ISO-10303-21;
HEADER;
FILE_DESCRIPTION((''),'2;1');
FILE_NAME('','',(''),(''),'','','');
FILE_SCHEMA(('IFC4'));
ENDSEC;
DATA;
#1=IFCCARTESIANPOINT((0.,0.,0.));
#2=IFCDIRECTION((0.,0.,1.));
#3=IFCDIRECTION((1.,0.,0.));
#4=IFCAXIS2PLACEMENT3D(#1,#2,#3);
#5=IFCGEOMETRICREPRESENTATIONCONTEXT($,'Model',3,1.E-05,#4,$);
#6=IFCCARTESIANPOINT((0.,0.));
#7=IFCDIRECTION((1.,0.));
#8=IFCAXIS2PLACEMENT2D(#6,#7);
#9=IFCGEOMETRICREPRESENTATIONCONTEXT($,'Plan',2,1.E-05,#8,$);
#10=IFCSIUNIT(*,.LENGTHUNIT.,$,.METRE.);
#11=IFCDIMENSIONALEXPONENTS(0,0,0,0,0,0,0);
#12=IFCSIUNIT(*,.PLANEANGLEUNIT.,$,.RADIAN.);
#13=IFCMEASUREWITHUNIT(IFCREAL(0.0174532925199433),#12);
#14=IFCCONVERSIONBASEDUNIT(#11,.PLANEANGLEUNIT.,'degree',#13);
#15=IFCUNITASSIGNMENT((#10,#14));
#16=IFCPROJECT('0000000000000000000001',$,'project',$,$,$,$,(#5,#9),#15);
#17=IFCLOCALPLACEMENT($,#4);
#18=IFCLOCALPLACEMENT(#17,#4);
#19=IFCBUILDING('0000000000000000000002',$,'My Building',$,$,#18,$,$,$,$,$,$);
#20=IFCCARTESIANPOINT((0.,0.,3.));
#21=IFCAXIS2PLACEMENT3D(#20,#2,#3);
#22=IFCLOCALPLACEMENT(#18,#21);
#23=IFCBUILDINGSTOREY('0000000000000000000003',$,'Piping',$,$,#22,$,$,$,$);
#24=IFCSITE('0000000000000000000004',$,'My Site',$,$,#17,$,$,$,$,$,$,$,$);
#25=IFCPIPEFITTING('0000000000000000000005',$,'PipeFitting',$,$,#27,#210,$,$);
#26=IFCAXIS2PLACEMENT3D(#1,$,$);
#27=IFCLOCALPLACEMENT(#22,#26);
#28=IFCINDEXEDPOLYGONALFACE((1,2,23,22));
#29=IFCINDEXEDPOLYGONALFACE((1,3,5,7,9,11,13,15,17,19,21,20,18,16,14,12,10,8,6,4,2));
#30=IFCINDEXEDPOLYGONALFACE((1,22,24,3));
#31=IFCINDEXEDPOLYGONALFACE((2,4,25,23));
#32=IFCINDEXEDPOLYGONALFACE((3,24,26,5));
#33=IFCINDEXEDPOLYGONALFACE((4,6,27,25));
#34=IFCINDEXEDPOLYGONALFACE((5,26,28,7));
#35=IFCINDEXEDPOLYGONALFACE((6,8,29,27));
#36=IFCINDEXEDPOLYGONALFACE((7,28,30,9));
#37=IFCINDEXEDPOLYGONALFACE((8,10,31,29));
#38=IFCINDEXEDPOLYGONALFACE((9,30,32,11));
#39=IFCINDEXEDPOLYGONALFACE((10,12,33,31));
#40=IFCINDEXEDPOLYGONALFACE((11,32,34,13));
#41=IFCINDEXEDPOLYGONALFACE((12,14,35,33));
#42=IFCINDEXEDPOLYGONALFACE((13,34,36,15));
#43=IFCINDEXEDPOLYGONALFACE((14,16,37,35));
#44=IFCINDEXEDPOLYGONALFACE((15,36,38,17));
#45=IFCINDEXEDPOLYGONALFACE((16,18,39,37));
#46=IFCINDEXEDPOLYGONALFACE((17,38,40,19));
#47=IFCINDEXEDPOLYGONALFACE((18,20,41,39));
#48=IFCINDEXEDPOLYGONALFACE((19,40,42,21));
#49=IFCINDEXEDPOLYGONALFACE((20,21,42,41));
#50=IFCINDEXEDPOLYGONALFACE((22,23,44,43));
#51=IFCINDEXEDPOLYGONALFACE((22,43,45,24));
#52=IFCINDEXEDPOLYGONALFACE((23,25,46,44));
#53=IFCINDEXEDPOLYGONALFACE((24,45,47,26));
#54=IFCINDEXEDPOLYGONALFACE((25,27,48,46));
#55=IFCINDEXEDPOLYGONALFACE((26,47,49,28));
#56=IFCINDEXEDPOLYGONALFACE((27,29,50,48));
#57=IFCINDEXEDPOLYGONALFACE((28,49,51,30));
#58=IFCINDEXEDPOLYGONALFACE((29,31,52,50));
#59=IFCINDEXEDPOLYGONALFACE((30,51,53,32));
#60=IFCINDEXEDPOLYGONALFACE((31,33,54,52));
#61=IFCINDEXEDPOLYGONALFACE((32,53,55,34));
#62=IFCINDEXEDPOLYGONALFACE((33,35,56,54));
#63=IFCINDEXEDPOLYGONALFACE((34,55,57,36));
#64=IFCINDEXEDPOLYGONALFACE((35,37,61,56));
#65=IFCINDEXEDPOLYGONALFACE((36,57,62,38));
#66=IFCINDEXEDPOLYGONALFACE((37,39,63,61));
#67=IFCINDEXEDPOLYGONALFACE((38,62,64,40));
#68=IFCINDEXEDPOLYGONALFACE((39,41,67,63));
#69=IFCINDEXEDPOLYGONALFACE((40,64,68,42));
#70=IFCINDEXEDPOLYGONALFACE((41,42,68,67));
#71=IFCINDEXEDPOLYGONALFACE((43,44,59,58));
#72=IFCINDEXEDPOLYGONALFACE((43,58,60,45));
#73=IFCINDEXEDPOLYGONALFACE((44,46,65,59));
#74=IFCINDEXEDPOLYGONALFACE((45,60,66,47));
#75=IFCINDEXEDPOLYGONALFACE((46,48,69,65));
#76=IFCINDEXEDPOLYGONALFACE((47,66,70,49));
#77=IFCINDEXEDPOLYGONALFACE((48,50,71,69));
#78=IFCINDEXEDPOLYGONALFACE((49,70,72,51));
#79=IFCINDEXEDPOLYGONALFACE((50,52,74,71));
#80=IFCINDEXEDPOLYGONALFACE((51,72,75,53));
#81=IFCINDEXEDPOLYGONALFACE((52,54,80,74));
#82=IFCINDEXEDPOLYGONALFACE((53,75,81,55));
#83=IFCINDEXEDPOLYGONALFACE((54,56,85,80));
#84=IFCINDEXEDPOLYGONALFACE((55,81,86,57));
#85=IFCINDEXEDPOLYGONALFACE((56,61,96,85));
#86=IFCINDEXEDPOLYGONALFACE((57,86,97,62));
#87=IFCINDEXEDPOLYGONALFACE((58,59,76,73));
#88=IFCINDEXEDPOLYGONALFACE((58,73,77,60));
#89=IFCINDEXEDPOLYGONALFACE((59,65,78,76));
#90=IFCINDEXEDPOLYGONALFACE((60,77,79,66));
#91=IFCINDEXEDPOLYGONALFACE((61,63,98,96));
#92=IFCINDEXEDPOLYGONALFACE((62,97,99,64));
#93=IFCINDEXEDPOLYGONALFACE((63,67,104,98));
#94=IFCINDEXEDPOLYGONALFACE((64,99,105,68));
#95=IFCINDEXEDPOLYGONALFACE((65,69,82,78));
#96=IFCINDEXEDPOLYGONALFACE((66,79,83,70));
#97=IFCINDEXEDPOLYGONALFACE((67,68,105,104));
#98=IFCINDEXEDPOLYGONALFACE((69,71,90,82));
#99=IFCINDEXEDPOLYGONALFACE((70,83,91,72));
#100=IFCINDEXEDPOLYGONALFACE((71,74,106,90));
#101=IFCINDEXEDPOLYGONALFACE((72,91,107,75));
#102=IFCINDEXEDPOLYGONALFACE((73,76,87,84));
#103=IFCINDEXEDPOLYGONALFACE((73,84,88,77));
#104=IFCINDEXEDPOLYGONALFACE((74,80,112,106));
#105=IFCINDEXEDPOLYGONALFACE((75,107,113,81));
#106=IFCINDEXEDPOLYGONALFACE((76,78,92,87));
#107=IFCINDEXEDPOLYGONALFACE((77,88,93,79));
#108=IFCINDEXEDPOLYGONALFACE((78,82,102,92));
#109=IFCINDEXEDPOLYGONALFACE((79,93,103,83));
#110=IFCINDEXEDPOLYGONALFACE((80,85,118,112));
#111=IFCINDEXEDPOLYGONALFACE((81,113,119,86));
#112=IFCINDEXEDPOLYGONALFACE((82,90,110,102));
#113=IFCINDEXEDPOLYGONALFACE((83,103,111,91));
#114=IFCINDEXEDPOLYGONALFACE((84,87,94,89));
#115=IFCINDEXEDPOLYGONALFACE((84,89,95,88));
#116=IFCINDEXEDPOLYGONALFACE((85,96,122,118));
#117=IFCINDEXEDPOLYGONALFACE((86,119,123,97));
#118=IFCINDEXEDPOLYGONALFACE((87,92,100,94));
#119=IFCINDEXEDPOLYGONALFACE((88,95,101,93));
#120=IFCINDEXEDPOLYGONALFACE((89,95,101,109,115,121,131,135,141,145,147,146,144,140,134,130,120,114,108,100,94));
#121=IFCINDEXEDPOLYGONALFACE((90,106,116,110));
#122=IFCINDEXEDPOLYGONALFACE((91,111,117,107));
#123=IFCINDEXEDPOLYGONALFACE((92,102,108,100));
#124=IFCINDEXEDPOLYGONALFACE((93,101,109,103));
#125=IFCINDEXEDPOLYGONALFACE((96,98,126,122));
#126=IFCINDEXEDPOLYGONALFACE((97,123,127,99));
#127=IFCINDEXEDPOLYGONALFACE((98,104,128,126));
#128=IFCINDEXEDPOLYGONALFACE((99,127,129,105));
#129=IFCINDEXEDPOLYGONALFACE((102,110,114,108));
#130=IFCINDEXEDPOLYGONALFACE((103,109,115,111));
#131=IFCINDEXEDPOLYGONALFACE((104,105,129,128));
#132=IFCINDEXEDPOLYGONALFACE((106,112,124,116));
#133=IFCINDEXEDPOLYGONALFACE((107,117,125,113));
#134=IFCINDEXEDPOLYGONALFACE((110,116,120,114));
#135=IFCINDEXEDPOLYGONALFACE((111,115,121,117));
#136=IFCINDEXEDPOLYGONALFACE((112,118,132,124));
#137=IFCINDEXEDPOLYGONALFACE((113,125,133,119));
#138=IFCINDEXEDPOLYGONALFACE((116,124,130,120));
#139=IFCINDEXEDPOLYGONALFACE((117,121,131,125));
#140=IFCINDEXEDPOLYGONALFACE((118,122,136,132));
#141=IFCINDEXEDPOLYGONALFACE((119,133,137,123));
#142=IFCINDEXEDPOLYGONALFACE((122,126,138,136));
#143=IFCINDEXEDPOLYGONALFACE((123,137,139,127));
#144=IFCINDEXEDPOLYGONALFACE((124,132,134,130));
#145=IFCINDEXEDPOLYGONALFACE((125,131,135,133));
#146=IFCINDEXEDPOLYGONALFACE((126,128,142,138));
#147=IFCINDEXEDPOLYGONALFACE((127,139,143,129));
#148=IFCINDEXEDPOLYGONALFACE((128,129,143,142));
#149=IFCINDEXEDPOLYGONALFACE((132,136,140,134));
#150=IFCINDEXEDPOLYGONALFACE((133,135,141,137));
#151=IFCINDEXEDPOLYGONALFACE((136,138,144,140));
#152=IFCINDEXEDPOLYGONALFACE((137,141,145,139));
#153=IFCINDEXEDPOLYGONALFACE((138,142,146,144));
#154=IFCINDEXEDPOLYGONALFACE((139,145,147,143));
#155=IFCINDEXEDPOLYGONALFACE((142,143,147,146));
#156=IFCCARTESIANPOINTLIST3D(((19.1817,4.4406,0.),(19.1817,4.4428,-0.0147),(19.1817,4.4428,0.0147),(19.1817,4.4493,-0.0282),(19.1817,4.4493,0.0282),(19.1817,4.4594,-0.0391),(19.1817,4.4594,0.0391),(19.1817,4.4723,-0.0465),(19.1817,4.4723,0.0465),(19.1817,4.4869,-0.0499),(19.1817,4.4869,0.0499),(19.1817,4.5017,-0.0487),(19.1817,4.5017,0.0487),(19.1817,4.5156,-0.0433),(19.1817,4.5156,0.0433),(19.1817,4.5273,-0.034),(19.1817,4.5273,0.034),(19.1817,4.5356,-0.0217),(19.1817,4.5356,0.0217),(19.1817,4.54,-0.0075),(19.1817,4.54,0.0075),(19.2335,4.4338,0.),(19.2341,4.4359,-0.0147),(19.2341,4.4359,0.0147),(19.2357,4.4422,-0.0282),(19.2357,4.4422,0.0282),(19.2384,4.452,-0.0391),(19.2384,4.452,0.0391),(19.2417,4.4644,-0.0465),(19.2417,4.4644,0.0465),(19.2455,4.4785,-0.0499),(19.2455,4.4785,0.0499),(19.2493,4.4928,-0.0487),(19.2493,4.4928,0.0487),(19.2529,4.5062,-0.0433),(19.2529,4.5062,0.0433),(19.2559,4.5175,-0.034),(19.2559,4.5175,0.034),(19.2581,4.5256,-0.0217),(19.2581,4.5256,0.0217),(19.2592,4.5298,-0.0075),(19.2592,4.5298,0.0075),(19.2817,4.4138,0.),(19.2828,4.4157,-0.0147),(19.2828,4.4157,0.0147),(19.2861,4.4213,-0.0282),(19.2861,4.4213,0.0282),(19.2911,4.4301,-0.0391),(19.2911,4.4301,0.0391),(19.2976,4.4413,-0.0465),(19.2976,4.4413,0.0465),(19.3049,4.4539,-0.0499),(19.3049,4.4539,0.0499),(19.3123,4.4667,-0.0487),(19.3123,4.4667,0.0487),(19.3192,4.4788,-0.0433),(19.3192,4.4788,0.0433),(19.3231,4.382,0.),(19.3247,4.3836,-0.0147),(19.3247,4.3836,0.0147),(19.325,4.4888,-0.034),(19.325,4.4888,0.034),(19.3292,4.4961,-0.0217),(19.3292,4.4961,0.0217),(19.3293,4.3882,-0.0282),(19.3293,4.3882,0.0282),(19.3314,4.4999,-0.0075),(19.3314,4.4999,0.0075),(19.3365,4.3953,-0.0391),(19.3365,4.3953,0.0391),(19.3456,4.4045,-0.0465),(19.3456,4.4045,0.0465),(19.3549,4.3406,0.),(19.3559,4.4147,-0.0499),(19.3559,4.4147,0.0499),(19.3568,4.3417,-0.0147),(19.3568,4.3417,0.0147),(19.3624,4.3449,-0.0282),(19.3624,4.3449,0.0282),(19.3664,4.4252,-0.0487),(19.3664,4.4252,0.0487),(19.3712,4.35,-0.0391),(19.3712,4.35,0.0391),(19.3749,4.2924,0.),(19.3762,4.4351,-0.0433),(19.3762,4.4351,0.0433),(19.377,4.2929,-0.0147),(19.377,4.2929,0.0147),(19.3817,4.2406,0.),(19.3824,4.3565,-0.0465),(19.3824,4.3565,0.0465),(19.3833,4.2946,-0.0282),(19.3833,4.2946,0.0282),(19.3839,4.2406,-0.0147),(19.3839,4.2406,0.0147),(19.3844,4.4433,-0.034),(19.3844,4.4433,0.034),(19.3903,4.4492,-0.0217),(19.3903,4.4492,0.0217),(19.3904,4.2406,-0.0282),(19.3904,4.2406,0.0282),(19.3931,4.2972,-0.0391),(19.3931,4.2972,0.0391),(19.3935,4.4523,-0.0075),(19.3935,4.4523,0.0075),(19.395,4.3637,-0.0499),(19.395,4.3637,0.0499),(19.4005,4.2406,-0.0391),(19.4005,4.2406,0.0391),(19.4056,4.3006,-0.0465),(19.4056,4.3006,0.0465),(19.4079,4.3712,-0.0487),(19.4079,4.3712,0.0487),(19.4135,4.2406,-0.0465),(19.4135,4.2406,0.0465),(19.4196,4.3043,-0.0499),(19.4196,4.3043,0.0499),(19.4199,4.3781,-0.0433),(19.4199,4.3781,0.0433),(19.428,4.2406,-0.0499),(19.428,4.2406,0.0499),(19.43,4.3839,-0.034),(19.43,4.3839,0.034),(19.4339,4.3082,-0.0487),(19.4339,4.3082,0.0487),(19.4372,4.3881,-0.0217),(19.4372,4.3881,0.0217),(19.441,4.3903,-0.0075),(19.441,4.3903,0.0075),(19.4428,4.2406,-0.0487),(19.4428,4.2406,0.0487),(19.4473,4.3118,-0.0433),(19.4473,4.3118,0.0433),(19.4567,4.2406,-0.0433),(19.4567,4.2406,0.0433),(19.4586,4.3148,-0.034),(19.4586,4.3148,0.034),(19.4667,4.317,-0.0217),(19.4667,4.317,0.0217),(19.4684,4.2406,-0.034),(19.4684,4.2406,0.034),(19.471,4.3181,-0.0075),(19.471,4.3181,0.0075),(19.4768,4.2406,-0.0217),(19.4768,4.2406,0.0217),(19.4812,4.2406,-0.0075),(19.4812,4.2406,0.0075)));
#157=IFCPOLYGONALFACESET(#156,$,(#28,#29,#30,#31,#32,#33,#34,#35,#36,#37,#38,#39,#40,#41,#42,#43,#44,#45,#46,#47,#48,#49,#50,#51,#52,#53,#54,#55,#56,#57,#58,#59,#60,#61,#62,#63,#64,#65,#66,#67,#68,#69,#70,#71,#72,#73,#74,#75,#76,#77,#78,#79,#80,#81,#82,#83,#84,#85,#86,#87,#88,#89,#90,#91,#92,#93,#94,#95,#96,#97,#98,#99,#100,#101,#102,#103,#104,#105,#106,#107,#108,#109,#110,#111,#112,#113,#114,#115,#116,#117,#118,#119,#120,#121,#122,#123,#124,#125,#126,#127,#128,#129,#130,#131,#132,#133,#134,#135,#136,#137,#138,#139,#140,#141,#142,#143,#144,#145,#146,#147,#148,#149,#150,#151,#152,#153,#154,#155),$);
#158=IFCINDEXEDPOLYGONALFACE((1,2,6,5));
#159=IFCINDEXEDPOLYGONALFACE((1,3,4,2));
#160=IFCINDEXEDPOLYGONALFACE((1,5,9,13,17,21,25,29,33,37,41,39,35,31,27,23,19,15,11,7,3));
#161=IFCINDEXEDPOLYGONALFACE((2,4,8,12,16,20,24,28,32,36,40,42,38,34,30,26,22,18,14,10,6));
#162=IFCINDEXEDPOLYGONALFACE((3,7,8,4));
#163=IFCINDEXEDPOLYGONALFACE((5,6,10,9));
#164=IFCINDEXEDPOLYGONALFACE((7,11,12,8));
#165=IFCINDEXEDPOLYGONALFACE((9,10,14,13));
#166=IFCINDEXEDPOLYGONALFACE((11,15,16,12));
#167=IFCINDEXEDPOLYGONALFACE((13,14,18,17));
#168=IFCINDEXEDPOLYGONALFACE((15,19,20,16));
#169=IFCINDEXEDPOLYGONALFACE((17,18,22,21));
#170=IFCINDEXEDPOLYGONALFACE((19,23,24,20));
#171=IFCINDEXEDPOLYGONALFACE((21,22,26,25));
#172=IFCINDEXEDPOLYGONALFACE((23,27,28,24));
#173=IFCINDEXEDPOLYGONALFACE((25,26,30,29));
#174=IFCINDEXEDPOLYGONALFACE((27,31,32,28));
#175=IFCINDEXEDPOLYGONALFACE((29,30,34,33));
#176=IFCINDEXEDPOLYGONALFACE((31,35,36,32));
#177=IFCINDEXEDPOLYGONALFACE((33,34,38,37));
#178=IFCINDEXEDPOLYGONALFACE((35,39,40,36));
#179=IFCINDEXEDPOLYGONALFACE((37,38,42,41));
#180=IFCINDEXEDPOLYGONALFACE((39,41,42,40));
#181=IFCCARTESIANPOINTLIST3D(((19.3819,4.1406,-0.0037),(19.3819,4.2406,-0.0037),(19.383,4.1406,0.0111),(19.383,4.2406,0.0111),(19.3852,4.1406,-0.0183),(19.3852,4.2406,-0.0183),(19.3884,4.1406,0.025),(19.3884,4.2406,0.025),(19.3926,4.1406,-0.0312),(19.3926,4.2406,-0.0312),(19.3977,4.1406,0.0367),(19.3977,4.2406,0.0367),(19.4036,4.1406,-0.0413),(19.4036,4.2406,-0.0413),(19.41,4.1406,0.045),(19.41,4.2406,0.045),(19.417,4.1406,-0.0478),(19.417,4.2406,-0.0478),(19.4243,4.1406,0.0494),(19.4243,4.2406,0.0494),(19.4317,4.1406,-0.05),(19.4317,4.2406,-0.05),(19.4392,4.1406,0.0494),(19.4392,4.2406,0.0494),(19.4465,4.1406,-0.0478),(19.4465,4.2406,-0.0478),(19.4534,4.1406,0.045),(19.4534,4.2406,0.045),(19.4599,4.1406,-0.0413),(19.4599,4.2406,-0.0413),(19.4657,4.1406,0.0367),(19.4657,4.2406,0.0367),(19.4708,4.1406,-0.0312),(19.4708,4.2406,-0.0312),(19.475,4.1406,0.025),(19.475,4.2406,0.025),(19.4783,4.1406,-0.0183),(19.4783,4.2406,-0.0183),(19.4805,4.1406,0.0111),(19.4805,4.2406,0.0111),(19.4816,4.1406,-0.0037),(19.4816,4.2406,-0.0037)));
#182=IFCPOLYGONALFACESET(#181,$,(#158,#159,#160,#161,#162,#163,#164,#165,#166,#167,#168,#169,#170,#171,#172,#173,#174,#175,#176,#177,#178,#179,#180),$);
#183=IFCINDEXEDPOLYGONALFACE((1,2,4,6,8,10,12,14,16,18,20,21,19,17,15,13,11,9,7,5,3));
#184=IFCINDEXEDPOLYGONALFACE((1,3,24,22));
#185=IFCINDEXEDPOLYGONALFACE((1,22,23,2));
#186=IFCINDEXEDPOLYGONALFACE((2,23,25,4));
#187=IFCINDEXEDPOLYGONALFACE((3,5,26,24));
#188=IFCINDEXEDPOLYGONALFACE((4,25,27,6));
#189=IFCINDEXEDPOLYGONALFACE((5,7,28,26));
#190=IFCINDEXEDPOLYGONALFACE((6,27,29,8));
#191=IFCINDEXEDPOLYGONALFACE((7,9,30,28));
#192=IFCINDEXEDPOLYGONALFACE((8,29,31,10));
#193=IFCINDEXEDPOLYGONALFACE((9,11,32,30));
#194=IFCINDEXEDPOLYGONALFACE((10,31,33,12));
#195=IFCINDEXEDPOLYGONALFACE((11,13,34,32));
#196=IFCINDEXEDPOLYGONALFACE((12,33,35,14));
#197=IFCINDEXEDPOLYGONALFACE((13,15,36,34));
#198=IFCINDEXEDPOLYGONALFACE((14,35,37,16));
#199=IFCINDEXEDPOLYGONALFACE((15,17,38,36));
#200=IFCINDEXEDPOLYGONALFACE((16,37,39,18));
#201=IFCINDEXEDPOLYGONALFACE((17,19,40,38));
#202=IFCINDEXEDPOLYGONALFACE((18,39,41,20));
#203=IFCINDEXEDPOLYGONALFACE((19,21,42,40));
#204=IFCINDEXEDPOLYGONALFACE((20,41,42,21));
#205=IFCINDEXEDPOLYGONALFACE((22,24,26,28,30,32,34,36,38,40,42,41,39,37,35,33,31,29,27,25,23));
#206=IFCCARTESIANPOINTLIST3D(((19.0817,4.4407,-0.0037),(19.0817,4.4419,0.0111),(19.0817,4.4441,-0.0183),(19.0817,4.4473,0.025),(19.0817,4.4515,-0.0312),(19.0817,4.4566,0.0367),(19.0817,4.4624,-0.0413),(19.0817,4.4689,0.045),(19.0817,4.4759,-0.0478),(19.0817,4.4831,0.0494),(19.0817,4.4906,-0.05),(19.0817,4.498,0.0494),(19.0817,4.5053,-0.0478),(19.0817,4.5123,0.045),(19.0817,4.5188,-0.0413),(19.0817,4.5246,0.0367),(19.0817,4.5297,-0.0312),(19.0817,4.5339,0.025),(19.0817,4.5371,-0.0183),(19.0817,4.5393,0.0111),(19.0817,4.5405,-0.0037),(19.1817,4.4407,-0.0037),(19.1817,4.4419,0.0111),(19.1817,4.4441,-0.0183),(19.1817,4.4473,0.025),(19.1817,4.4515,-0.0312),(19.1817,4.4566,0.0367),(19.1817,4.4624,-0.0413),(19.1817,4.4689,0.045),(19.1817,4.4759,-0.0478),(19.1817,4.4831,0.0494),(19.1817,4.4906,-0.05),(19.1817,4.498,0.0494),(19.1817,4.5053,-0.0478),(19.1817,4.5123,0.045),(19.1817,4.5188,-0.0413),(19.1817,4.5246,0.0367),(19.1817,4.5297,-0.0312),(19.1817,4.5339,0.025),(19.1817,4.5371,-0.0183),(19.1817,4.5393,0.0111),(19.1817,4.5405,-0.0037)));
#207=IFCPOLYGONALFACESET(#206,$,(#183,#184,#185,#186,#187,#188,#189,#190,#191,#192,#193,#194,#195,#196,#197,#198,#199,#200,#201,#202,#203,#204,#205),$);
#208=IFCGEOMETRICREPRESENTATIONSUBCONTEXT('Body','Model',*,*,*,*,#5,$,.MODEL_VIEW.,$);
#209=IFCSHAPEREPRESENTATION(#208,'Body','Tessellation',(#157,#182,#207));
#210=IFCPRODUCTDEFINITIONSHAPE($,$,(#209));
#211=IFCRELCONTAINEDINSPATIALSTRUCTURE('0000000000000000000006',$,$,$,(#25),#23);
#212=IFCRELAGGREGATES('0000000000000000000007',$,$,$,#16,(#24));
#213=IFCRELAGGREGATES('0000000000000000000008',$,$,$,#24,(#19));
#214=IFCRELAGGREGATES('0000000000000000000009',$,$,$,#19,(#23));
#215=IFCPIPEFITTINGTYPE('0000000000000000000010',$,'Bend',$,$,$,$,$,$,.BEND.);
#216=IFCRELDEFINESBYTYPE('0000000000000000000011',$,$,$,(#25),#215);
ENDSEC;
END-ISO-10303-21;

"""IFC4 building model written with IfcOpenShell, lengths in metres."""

from ifc_helpers import new_model, entity, si_unit, converted_unit, frame, origin_with_axes, origin_2d_with_axis, place, context, subcontext, project, spatial, circle, extrude, source, transform, mapped, type_object, type_shapes, element, save


model = new_model("IFC4")

# Units and contexts
model_context = context("Model", 3, precision=1e-05, world=origin_with_axes())
plan_context = context("Plan", 2, precision=1e-05, world=origin_2d_with_axis())
body_context = subcontext(model_context, "Body", "Model", "MODEL_VIEW")
ifc_project = project(units=[si_unit("LENGTHUNIT", "METRE"), converted_unit("PLANEANGLEUNIT", "degree", entity("IfcReal", 0.0174532925199433), si_unit("PLANEANGLEUNIT", "RADIAN"), dimensions=[0, 0, 0, 0, 0, 0, 0])], contexts=[model_context, plan_context])

# Site, building, storey
site_placement = place(None, origin_with_axes())
site = spatial("IfcSite", under=ifc_project, at=site_placement, Name="My Site")
building_placement = place(site_placement, origin_with_axes())
building = spatial("IfcBuilding", under=site, at=building_placement, Name="My Building")
storey_placement = place(building_placement, frame((0.0, 0.0, 3.0), z_axis=(0.0, 0.0, 1.0), x_axis=(1.0, 0.0, 0.0)))
storey = spatial("IfcBuildingStorey", under=building, at=storey_placement, Name="Piping")

# Pipe fitting
pipe_fitting_type = type_object("IfcPipeFittingType", Name="Bend", PredefinedType="BEND")
shared_shape = source(origin_with_axes(), body_context, "Body", "SolidModel", [
    entity("IfcSweptDiskSolid", entity("IfcIndexedPolyCurve", entity("IfcCartesianPointList3D", [[0.0, 0.0, -0.1], [0.0, -0.0732, -0.2768], [0.0, -0.25, -0.35]]), [entity("IfcArcIndex", [1, 2, 3])]), 0.05),
    extrude(circle(Radius=0.05), origin_with_axes(), (0.0, 0.0, -1.0), 0.1),
    extrude(circle(Radius=0.05), frame((0.0, -0.25, -0.35), z_axis=(0.0, -1.0, 0.0), x_axis=(1.0, 0.0, 0.0)), (0.0, 0.0, 1.0), 0.1),
])
type_shapes(pipe_fitting_type, [shared_shape])
for number, where, z_axis, x_axis, name in (
    (1, (19.4317, 4.1406, 0.0), (0.0, -1.0, 0.0), (0.0, 0.0, -1.0), "PipeFitting"),
):
    element("IfcPipeFitting", number, at=place(storey_placement, frame(where, z_axis=z_axis, x_axis=x_axis)), inside=storey, type_object=pipe_fitting_type, Name=name, context=body_context, shape_type="MappedRepresentation", body=[
        mapped(shared_shape, transform((0.0, 0.0, 0.0), x_axis=(1.0, 0.0, 0.0), y_axis=(0.0, 1.0, 0.0), z_axis=(0.0, 0.0, 1.0), scale=1.0)),
    ])

save(model, "model.ifc")
